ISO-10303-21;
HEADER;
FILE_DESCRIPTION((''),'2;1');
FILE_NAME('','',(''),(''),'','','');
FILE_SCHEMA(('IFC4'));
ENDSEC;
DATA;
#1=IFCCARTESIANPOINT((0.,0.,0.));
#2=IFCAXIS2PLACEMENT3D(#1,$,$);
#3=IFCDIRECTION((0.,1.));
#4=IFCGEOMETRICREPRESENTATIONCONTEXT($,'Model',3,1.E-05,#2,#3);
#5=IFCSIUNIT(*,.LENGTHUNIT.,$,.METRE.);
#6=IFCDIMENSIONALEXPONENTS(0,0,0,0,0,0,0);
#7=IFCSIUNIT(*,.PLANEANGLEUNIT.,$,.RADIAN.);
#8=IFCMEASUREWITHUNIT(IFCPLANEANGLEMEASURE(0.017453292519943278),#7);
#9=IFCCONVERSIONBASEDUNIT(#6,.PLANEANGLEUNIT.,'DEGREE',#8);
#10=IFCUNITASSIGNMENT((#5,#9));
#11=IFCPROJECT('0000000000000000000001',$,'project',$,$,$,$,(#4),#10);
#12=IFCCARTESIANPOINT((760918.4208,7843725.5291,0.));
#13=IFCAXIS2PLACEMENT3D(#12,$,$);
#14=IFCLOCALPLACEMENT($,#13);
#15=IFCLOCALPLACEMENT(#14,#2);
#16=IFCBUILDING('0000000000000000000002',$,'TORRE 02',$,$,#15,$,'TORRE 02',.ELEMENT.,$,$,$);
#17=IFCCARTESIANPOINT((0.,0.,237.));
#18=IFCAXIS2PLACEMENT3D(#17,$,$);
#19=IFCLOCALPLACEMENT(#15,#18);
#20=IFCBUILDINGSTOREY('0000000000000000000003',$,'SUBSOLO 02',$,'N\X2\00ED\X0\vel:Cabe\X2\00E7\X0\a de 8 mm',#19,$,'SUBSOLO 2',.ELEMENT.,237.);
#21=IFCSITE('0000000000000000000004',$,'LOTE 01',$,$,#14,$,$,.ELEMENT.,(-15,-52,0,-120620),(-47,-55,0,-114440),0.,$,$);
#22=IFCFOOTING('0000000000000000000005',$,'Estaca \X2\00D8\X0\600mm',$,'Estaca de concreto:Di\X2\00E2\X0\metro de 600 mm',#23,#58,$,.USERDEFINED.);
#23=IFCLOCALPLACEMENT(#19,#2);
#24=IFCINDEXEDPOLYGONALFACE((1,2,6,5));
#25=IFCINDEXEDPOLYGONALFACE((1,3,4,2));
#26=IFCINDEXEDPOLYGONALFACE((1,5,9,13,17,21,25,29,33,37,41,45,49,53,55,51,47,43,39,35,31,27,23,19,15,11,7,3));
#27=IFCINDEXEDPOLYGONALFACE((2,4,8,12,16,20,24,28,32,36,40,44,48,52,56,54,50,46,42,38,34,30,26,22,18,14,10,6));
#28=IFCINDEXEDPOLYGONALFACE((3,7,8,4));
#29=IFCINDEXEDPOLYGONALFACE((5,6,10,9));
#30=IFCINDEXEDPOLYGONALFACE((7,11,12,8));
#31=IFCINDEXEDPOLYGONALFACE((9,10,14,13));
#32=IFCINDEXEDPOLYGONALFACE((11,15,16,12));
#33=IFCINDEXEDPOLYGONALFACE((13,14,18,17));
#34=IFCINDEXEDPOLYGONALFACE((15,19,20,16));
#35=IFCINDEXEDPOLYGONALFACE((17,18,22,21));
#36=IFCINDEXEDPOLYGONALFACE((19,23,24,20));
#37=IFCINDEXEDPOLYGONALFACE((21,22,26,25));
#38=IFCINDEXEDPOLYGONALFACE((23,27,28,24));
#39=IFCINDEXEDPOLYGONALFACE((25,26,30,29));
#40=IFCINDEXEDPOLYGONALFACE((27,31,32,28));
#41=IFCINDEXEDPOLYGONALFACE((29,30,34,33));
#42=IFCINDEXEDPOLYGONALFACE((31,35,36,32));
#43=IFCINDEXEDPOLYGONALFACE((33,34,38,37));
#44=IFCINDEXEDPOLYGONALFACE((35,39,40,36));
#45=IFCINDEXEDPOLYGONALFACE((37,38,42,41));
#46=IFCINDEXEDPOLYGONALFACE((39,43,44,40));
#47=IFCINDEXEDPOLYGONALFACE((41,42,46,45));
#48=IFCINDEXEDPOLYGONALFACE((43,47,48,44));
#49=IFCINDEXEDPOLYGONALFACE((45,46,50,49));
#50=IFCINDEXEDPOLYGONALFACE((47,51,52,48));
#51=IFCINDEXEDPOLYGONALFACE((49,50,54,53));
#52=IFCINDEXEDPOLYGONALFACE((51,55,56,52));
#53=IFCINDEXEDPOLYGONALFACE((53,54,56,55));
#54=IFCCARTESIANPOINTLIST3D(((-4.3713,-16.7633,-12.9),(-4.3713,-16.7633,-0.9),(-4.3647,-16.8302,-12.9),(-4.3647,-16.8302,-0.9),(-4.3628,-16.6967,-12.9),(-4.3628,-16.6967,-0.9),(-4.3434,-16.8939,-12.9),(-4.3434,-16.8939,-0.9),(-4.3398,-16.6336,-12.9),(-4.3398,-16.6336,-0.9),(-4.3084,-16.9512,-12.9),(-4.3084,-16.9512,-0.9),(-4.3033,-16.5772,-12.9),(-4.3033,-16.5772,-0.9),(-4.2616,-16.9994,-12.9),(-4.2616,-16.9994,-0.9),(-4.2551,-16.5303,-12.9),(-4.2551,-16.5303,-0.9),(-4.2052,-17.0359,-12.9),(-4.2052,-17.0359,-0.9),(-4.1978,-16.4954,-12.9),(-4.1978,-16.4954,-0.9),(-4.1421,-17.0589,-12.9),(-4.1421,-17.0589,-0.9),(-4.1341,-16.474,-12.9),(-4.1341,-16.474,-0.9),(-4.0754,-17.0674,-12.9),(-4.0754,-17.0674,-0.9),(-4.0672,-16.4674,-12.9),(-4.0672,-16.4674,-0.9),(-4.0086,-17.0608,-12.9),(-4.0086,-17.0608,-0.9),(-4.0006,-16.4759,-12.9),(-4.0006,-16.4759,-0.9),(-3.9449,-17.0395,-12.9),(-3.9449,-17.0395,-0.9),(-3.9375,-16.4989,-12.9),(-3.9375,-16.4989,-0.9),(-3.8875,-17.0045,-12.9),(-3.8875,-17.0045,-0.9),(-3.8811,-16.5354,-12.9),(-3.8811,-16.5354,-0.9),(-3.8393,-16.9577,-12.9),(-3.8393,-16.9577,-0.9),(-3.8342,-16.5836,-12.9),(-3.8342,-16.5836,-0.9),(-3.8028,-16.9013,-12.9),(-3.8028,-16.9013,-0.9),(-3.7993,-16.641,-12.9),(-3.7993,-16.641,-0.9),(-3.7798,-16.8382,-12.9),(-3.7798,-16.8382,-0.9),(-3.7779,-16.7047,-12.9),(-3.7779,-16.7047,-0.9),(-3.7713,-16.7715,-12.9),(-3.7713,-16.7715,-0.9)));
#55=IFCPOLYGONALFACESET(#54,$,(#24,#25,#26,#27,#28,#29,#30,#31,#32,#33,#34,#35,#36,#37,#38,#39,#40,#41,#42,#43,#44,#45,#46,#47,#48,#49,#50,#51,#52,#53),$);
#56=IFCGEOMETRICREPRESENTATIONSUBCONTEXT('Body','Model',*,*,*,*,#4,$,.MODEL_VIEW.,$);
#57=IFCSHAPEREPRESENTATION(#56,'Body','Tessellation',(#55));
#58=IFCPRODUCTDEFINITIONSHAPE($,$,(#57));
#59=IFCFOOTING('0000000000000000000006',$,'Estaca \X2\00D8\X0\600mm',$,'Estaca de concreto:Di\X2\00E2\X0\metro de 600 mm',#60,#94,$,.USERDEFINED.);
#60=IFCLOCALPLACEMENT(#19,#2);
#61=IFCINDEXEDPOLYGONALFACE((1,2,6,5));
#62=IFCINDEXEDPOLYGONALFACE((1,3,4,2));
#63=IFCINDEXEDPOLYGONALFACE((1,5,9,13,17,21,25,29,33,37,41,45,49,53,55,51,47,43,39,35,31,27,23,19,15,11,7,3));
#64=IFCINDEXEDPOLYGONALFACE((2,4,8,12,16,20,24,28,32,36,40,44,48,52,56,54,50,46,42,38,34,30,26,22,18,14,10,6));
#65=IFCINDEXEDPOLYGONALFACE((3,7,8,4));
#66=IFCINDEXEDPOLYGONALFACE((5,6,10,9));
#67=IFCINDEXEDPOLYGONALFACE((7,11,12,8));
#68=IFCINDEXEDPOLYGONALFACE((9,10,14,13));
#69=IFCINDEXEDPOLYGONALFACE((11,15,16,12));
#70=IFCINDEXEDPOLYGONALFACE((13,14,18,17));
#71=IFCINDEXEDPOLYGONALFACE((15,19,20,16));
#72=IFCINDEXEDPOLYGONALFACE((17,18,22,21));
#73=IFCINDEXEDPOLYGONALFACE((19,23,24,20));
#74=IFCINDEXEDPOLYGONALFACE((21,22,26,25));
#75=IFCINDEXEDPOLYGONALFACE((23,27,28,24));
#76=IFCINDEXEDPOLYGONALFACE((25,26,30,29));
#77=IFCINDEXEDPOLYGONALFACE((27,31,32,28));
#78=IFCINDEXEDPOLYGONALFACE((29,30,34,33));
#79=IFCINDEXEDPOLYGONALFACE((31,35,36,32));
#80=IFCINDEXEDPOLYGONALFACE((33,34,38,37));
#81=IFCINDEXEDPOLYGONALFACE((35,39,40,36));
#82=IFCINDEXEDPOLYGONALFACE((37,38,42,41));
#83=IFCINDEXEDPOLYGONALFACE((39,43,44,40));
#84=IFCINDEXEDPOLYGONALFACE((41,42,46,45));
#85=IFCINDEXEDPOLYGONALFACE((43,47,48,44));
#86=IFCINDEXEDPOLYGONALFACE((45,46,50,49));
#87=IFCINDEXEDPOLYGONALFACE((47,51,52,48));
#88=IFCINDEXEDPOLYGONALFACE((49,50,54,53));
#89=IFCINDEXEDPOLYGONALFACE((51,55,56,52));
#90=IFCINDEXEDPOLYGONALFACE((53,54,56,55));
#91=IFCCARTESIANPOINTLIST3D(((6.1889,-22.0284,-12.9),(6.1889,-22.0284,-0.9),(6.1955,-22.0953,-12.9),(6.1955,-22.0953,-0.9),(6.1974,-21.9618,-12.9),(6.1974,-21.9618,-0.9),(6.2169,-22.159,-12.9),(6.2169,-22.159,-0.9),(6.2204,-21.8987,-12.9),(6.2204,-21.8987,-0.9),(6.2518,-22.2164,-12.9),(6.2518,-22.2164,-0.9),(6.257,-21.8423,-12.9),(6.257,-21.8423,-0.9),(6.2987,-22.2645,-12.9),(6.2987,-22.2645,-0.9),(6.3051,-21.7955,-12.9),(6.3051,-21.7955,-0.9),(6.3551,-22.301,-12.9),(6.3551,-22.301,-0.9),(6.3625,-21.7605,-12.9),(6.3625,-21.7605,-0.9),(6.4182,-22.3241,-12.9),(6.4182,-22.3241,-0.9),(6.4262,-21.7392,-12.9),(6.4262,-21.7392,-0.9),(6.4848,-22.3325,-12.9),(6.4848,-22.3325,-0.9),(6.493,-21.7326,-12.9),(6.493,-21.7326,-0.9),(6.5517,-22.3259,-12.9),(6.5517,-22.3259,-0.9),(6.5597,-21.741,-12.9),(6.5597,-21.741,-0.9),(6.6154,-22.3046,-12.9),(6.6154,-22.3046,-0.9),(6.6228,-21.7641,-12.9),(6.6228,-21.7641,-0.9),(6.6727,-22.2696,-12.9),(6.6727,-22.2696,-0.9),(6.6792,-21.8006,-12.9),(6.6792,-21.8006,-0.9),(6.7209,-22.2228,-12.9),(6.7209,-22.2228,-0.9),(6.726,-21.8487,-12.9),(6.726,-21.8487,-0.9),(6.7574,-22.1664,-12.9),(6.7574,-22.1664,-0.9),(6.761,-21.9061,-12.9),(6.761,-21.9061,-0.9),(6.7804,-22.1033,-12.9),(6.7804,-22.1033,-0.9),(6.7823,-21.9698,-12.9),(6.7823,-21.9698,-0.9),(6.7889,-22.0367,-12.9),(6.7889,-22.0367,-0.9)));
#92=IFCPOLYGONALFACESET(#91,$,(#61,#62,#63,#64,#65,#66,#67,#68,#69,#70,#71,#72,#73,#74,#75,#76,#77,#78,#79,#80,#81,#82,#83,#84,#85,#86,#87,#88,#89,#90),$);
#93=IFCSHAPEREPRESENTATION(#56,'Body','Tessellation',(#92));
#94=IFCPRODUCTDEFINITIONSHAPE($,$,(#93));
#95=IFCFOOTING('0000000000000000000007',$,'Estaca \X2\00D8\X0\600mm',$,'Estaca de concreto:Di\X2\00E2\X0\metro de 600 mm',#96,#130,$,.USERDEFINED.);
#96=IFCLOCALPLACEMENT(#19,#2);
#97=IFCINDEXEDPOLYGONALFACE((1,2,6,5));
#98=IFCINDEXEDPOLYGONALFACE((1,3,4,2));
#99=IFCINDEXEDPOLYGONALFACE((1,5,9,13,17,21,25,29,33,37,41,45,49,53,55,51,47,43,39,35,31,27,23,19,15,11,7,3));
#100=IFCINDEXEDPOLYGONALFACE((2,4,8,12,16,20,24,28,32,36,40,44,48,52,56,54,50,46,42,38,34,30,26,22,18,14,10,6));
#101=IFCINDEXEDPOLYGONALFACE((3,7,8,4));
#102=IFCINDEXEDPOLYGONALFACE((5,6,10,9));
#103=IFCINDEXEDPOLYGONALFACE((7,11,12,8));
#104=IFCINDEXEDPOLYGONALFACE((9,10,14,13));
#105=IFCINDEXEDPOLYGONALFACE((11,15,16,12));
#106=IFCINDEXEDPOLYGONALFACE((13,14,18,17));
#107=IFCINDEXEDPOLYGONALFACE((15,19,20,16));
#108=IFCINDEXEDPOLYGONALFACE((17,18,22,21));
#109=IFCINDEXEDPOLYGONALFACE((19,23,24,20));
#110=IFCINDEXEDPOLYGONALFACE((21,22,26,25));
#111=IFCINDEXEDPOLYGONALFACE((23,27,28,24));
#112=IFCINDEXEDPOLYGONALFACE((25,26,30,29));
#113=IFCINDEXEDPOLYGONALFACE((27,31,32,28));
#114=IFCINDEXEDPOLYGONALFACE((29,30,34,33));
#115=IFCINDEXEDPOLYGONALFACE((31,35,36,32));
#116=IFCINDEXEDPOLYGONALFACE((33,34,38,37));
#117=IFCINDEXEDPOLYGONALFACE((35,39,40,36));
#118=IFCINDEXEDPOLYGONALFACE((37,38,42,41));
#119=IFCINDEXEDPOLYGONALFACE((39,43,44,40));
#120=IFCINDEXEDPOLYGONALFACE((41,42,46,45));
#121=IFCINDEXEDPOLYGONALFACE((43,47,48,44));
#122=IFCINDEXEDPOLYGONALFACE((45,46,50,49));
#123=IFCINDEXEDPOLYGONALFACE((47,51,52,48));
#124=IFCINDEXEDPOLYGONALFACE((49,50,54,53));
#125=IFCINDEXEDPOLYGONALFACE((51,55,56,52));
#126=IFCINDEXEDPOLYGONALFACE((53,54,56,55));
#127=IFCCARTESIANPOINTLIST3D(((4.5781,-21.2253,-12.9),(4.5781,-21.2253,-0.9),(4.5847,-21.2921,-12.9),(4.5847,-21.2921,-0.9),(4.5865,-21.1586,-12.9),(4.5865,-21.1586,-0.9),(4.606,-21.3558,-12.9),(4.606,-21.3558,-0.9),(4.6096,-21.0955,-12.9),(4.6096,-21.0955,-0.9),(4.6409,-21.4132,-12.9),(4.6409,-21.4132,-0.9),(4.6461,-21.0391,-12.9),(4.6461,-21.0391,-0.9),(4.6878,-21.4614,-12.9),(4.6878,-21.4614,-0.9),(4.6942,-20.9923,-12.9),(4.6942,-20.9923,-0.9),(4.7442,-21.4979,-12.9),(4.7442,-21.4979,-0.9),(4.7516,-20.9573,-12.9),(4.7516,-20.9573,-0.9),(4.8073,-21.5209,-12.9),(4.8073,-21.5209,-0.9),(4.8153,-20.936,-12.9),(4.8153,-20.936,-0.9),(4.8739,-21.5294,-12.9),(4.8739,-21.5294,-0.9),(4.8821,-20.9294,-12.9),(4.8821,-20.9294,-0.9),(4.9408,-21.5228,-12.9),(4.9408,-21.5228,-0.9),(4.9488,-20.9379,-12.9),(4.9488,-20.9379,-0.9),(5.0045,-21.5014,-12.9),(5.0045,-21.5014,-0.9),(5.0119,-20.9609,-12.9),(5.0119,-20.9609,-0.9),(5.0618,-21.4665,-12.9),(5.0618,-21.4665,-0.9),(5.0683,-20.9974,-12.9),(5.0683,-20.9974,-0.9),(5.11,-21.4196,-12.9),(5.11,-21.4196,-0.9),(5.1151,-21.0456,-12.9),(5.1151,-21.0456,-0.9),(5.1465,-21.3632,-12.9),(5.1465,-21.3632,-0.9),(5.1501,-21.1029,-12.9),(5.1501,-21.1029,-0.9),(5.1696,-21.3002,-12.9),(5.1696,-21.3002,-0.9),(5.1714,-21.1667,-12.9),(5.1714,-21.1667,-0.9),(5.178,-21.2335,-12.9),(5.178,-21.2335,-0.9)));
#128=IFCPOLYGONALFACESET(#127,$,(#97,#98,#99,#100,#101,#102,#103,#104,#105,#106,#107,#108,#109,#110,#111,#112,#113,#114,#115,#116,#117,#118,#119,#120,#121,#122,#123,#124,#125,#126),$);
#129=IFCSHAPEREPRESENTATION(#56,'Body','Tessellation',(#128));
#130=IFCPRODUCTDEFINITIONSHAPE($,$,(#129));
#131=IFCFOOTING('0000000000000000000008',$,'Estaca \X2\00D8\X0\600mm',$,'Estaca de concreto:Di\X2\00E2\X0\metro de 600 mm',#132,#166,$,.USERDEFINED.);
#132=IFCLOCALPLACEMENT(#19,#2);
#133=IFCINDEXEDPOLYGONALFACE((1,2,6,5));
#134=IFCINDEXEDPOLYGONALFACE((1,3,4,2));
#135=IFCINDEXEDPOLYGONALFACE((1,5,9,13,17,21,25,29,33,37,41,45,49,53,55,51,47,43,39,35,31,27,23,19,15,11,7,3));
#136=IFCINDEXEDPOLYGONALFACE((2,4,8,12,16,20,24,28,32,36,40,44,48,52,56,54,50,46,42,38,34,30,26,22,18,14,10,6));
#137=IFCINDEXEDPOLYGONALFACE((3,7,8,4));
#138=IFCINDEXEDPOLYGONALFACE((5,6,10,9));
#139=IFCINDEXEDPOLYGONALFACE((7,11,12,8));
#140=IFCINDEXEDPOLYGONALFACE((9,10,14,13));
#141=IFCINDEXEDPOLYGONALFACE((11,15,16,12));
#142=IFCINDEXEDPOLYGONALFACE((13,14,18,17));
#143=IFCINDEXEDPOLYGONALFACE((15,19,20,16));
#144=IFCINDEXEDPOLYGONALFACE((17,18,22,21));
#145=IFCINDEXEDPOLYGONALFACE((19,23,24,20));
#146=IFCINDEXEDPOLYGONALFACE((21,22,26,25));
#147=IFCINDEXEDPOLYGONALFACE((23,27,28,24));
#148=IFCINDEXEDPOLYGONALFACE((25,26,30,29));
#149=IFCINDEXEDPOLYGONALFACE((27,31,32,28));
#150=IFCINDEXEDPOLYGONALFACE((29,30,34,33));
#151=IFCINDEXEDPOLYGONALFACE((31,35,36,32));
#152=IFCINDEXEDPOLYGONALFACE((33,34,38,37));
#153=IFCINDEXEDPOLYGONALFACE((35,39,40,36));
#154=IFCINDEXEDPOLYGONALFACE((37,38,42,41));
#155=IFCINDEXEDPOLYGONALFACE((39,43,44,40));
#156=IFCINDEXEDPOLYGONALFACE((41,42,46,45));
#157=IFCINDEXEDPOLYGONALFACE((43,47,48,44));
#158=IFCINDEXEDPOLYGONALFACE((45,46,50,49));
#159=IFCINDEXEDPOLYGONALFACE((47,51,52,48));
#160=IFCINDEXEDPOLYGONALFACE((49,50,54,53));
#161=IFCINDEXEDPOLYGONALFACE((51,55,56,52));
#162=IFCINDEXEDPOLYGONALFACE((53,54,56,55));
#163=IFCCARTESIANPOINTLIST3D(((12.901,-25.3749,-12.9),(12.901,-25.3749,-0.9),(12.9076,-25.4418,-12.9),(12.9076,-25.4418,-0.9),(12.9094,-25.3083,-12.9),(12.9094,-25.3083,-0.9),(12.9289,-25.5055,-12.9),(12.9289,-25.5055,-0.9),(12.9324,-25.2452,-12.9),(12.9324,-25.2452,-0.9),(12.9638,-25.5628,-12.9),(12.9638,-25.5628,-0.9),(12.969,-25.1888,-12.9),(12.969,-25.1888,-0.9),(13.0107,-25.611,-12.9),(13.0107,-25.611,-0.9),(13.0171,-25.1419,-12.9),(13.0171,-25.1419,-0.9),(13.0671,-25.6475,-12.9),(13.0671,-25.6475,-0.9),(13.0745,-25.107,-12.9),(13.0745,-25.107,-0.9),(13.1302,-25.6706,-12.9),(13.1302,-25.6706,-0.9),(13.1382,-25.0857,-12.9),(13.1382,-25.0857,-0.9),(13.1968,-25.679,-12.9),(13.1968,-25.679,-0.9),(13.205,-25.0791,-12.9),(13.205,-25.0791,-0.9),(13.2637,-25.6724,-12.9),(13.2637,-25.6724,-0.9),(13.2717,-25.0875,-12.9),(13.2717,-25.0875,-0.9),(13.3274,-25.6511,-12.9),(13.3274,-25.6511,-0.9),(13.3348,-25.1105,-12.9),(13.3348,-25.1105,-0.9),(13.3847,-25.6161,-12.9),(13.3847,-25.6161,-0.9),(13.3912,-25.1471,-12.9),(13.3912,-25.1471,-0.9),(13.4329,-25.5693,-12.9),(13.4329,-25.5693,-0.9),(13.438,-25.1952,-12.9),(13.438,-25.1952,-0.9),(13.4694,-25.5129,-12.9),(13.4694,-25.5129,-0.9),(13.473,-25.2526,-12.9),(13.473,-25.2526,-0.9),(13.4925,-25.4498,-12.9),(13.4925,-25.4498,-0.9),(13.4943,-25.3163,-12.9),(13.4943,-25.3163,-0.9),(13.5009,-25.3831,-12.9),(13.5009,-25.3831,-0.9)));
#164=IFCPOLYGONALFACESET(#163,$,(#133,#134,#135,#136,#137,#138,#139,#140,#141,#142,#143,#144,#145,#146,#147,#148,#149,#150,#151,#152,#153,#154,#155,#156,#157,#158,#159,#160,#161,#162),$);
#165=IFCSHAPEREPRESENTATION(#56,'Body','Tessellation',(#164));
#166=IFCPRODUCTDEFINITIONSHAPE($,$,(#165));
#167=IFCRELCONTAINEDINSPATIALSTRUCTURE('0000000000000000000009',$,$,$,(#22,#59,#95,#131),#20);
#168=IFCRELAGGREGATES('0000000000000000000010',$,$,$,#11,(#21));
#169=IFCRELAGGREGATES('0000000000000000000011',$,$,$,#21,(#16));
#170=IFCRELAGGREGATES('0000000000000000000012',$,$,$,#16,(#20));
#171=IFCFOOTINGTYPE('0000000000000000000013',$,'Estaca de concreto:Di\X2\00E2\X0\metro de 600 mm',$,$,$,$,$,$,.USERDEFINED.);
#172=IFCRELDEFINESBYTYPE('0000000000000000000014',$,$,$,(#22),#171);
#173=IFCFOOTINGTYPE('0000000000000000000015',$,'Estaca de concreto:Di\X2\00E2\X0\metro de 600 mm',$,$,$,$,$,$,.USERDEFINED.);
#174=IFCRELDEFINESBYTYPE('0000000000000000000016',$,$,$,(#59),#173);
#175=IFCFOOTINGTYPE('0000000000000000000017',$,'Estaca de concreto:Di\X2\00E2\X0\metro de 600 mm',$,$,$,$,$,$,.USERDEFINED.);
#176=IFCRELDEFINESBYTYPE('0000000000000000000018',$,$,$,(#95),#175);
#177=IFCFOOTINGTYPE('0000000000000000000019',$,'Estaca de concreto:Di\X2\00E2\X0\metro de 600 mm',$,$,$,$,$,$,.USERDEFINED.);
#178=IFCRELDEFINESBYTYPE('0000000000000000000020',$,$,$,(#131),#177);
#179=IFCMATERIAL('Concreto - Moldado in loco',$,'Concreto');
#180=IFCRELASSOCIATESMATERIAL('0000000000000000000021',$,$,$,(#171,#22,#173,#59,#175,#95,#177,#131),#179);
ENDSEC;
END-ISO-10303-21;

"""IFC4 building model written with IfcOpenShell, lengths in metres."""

from ifc_helpers import new_model, entity, si_unit, converted_unit, direction, frame, origin, place, context, subcontext, project, spatial, arc, indexed_curve, outline, extrude, source, transform, mapped, material, type_object, type_shapes, element, save


model = new_model("IFC4")

# Units and contexts
model_context = context("Model", 3, precision=1e-05, world=origin(), true_north=direction((0.0, 1.0)))
body_context = subcontext(model_context, "Body", "Model", "MODEL_VIEW")
ifc_project = project(units=[si_unit("LENGTHUNIT", "METRE"), converted_unit("PLANEANGLEUNIT", "DEGREE", entity("IfcPlaneAngleMeasure", 0.017453292519943278), si_unit("PLANEANGLEUNIT", "RADIAN"), dimensions=[0, 0, 0, 0, 0, 0, 0])], contexts=[model_context])

# Site, building, storey
site_placement = place(None, frame((760918.4208, 7843725.5291, 0.0)))
site = spatial("IfcSite", under=ifc_project, at=site_placement, Name="LOTE 01", CompositionType="ELEMENT", RefLatitude=(-15, -52, 0, -120620), RefLongitude=(-47, -55, 0, -114440), RefElevation=0.0)
building_placement = place(site_placement, origin())
building = spatial("IfcBuilding", under=site, at=building_placement, Name="TORRE 02", LongName="TORRE 02", CompositionType="ELEMENT")
storey_placement = place(building_placement, frame((0.0, 0.0, 237.0)))
storey = spatial("IfcBuildingStorey", under=building, at=storey_placement, Name="SUBSOLO 02", ObjectType="Nível:Cabeça de 8 mm", LongName="SUBSOLO 2", CompositionType="ELEMENT", Elevation=237.0)

# Footings
ifc_material_1 = material(Name="Concreto - Moldado in loco", Category="Concreto")
placement = place(building_placement, frame((0.0, 0.0, 237.0)))
footing_type_1 = type_object("IfcFootingType", Name="Estaca de concreto:Diâmetro de 600 mm", PredefinedType="USERDEFINED", material=ifc_material_1)
shared_shape_1 = source(origin(), body_context, "Body", "SweptSolid", [
    extrude(outline(indexed_curve([(-0.3, 0.0), (0.0, -0.3), (0.3, 0.0), (0.0, 0.3)], segments=[arc(1, 2, 3), arc(3, 4, 1)], self_intersect=False)), frame((-4.0713, -16.7674, -12.0), z_axis=(0.0, 0.0, 1.0), x_axis=(-0.894934, 0.446198, 0.0)), (0.0, 0.0, 1.0), 12.0),
])
type_shapes(footing_type_1, [shared_shape_1])
footing_1_placement = place(placement, frame((0.0, 0.0, -0.9)))
element("IfcFooting", 1, at=footing_1_placement, inside=storey, type_object=footing_type_1, material=ifc_material_1, Name="Estaca Ø600mm", ObjectType="Estaca de concreto:Diâmetro de 600 mm", PredefinedType="USERDEFINED", context=body_context, shape_type="MappedRepresentation", body=[
    mapped(shared_shape_1, transform((0.0, 0.0, 0.0), scale=1.0)),
])
footing_type_2 = type_object("IfcFootingType", Name="Estaca de concreto:Diâmetro de 600 mm", PredefinedType="USERDEFINED", material=ifc_material_1)
shared_shape_2 = source(origin(), body_context, "Body", "SweptSolid", [
    extrude(outline(indexed_curve([(-0.3, 0.0), (0.0, -0.3), (0.3, 0.0), (0.0, 0.3)], segments=[arc(1, 2, 3), arc(3, 4, 1)], self_intersect=False)), frame((6.4889, -22.0325, -12.0), z_axis=(0.0, 0.0, 1.0), x_axis=(-0.894934, 0.446198, 0.0)), (0.0, 0.0, 1.0), 12.0),
])
type_shapes(footing_type_2, [shared_shape_2])
footing_2_placement = place(placement, frame((0.0, 0.0, -0.9)))
element("IfcFooting", 2, at=footing_2_placement, inside=storey, type_object=footing_type_2, material=ifc_material_1, Name="Estaca Ø600mm", ObjectType="Estaca de concreto:Diâmetro de 600 mm", PredefinedType="USERDEFINED", context=body_context, shape_type="MappedRepresentation", body=[
    mapped(shared_shape_2, transform((0.0, 0.0, 0.0), scale=1.0)),
])
footing_type_3 = type_object("IfcFootingType", Name="Estaca de concreto:Diâmetro de 600 mm", PredefinedType="USERDEFINED", material=ifc_material_1)
shared_shape_3 = source(origin(), body_context, "Body", "SweptSolid", [
    extrude(outline(indexed_curve([(-0.3, 0.0), (0.0, -0.3), (0.3, 0.0), (0.0, 0.3)], segments=[arc(1, 2, 3), arc(3, 4, 1)], self_intersect=False)), frame((4.878, -21.2294, -12.0), z_axis=(0.0, 0.0, 1.0), x_axis=(-0.894934, 0.446198, 0.0)), (0.0, 0.0, 1.0), 12.0),
])
type_shapes(footing_type_3, [shared_shape_3])
footing_3_placement = place(placement, frame((0.0, 0.0, -0.9)))
element("IfcFooting", 3, at=footing_3_placement, inside=storey, type_object=footing_type_3, material=ifc_material_1, Name="Estaca Ø600mm", ObjectType="Estaca de concreto:Diâmetro de 600 mm", PredefinedType="USERDEFINED", context=body_context, shape_type="MappedRepresentation", body=[
    mapped(shared_shape_3, transform((0.0, 0.0, 0.0), scale=1.0)),
])
footing_type_4 = type_object("IfcFootingType", Name="Estaca de concreto:Diâmetro de 600 mm", PredefinedType="USERDEFINED", material=ifc_material_1)
shared_shape_4 = source(origin(), body_context, "Body", "SweptSolid", [
    extrude(outline(indexed_curve([(-0.3, 0.0), (0.0, -0.3), (0.3, 0.0), (0.0, 0.3)], segments=[arc(1, 2, 3), arc(3, 4, 1)], self_intersect=False)), frame((13.2009, -25.379, -12.0), z_axis=(0.0, 0.0, 1.0), x_axis=(-0.894934, 0.446198, 0.0)), (0.0, 0.0, 1.0), 12.0),
])
type_shapes(footing_type_4, [shared_shape_4])
footing_4_placement = place(placement, frame((0.0, 0.0, -0.9)))
element("IfcFooting", 4, at=footing_4_placement, inside=storey, type_object=footing_type_4, material=ifc_material_1, Name="Estaca Ø600mm", ObjectType="Estaca de concreto:Diâmetro de 600 mm", PredefinedType="USERDEFINED", context=body_context, shape_type="MappedRepresentation", body=[
    mapped(shared_shape_4, transform((0.0, 0.0, 0.0), scale=1.0)),
])

save(model, "model.ifc")
